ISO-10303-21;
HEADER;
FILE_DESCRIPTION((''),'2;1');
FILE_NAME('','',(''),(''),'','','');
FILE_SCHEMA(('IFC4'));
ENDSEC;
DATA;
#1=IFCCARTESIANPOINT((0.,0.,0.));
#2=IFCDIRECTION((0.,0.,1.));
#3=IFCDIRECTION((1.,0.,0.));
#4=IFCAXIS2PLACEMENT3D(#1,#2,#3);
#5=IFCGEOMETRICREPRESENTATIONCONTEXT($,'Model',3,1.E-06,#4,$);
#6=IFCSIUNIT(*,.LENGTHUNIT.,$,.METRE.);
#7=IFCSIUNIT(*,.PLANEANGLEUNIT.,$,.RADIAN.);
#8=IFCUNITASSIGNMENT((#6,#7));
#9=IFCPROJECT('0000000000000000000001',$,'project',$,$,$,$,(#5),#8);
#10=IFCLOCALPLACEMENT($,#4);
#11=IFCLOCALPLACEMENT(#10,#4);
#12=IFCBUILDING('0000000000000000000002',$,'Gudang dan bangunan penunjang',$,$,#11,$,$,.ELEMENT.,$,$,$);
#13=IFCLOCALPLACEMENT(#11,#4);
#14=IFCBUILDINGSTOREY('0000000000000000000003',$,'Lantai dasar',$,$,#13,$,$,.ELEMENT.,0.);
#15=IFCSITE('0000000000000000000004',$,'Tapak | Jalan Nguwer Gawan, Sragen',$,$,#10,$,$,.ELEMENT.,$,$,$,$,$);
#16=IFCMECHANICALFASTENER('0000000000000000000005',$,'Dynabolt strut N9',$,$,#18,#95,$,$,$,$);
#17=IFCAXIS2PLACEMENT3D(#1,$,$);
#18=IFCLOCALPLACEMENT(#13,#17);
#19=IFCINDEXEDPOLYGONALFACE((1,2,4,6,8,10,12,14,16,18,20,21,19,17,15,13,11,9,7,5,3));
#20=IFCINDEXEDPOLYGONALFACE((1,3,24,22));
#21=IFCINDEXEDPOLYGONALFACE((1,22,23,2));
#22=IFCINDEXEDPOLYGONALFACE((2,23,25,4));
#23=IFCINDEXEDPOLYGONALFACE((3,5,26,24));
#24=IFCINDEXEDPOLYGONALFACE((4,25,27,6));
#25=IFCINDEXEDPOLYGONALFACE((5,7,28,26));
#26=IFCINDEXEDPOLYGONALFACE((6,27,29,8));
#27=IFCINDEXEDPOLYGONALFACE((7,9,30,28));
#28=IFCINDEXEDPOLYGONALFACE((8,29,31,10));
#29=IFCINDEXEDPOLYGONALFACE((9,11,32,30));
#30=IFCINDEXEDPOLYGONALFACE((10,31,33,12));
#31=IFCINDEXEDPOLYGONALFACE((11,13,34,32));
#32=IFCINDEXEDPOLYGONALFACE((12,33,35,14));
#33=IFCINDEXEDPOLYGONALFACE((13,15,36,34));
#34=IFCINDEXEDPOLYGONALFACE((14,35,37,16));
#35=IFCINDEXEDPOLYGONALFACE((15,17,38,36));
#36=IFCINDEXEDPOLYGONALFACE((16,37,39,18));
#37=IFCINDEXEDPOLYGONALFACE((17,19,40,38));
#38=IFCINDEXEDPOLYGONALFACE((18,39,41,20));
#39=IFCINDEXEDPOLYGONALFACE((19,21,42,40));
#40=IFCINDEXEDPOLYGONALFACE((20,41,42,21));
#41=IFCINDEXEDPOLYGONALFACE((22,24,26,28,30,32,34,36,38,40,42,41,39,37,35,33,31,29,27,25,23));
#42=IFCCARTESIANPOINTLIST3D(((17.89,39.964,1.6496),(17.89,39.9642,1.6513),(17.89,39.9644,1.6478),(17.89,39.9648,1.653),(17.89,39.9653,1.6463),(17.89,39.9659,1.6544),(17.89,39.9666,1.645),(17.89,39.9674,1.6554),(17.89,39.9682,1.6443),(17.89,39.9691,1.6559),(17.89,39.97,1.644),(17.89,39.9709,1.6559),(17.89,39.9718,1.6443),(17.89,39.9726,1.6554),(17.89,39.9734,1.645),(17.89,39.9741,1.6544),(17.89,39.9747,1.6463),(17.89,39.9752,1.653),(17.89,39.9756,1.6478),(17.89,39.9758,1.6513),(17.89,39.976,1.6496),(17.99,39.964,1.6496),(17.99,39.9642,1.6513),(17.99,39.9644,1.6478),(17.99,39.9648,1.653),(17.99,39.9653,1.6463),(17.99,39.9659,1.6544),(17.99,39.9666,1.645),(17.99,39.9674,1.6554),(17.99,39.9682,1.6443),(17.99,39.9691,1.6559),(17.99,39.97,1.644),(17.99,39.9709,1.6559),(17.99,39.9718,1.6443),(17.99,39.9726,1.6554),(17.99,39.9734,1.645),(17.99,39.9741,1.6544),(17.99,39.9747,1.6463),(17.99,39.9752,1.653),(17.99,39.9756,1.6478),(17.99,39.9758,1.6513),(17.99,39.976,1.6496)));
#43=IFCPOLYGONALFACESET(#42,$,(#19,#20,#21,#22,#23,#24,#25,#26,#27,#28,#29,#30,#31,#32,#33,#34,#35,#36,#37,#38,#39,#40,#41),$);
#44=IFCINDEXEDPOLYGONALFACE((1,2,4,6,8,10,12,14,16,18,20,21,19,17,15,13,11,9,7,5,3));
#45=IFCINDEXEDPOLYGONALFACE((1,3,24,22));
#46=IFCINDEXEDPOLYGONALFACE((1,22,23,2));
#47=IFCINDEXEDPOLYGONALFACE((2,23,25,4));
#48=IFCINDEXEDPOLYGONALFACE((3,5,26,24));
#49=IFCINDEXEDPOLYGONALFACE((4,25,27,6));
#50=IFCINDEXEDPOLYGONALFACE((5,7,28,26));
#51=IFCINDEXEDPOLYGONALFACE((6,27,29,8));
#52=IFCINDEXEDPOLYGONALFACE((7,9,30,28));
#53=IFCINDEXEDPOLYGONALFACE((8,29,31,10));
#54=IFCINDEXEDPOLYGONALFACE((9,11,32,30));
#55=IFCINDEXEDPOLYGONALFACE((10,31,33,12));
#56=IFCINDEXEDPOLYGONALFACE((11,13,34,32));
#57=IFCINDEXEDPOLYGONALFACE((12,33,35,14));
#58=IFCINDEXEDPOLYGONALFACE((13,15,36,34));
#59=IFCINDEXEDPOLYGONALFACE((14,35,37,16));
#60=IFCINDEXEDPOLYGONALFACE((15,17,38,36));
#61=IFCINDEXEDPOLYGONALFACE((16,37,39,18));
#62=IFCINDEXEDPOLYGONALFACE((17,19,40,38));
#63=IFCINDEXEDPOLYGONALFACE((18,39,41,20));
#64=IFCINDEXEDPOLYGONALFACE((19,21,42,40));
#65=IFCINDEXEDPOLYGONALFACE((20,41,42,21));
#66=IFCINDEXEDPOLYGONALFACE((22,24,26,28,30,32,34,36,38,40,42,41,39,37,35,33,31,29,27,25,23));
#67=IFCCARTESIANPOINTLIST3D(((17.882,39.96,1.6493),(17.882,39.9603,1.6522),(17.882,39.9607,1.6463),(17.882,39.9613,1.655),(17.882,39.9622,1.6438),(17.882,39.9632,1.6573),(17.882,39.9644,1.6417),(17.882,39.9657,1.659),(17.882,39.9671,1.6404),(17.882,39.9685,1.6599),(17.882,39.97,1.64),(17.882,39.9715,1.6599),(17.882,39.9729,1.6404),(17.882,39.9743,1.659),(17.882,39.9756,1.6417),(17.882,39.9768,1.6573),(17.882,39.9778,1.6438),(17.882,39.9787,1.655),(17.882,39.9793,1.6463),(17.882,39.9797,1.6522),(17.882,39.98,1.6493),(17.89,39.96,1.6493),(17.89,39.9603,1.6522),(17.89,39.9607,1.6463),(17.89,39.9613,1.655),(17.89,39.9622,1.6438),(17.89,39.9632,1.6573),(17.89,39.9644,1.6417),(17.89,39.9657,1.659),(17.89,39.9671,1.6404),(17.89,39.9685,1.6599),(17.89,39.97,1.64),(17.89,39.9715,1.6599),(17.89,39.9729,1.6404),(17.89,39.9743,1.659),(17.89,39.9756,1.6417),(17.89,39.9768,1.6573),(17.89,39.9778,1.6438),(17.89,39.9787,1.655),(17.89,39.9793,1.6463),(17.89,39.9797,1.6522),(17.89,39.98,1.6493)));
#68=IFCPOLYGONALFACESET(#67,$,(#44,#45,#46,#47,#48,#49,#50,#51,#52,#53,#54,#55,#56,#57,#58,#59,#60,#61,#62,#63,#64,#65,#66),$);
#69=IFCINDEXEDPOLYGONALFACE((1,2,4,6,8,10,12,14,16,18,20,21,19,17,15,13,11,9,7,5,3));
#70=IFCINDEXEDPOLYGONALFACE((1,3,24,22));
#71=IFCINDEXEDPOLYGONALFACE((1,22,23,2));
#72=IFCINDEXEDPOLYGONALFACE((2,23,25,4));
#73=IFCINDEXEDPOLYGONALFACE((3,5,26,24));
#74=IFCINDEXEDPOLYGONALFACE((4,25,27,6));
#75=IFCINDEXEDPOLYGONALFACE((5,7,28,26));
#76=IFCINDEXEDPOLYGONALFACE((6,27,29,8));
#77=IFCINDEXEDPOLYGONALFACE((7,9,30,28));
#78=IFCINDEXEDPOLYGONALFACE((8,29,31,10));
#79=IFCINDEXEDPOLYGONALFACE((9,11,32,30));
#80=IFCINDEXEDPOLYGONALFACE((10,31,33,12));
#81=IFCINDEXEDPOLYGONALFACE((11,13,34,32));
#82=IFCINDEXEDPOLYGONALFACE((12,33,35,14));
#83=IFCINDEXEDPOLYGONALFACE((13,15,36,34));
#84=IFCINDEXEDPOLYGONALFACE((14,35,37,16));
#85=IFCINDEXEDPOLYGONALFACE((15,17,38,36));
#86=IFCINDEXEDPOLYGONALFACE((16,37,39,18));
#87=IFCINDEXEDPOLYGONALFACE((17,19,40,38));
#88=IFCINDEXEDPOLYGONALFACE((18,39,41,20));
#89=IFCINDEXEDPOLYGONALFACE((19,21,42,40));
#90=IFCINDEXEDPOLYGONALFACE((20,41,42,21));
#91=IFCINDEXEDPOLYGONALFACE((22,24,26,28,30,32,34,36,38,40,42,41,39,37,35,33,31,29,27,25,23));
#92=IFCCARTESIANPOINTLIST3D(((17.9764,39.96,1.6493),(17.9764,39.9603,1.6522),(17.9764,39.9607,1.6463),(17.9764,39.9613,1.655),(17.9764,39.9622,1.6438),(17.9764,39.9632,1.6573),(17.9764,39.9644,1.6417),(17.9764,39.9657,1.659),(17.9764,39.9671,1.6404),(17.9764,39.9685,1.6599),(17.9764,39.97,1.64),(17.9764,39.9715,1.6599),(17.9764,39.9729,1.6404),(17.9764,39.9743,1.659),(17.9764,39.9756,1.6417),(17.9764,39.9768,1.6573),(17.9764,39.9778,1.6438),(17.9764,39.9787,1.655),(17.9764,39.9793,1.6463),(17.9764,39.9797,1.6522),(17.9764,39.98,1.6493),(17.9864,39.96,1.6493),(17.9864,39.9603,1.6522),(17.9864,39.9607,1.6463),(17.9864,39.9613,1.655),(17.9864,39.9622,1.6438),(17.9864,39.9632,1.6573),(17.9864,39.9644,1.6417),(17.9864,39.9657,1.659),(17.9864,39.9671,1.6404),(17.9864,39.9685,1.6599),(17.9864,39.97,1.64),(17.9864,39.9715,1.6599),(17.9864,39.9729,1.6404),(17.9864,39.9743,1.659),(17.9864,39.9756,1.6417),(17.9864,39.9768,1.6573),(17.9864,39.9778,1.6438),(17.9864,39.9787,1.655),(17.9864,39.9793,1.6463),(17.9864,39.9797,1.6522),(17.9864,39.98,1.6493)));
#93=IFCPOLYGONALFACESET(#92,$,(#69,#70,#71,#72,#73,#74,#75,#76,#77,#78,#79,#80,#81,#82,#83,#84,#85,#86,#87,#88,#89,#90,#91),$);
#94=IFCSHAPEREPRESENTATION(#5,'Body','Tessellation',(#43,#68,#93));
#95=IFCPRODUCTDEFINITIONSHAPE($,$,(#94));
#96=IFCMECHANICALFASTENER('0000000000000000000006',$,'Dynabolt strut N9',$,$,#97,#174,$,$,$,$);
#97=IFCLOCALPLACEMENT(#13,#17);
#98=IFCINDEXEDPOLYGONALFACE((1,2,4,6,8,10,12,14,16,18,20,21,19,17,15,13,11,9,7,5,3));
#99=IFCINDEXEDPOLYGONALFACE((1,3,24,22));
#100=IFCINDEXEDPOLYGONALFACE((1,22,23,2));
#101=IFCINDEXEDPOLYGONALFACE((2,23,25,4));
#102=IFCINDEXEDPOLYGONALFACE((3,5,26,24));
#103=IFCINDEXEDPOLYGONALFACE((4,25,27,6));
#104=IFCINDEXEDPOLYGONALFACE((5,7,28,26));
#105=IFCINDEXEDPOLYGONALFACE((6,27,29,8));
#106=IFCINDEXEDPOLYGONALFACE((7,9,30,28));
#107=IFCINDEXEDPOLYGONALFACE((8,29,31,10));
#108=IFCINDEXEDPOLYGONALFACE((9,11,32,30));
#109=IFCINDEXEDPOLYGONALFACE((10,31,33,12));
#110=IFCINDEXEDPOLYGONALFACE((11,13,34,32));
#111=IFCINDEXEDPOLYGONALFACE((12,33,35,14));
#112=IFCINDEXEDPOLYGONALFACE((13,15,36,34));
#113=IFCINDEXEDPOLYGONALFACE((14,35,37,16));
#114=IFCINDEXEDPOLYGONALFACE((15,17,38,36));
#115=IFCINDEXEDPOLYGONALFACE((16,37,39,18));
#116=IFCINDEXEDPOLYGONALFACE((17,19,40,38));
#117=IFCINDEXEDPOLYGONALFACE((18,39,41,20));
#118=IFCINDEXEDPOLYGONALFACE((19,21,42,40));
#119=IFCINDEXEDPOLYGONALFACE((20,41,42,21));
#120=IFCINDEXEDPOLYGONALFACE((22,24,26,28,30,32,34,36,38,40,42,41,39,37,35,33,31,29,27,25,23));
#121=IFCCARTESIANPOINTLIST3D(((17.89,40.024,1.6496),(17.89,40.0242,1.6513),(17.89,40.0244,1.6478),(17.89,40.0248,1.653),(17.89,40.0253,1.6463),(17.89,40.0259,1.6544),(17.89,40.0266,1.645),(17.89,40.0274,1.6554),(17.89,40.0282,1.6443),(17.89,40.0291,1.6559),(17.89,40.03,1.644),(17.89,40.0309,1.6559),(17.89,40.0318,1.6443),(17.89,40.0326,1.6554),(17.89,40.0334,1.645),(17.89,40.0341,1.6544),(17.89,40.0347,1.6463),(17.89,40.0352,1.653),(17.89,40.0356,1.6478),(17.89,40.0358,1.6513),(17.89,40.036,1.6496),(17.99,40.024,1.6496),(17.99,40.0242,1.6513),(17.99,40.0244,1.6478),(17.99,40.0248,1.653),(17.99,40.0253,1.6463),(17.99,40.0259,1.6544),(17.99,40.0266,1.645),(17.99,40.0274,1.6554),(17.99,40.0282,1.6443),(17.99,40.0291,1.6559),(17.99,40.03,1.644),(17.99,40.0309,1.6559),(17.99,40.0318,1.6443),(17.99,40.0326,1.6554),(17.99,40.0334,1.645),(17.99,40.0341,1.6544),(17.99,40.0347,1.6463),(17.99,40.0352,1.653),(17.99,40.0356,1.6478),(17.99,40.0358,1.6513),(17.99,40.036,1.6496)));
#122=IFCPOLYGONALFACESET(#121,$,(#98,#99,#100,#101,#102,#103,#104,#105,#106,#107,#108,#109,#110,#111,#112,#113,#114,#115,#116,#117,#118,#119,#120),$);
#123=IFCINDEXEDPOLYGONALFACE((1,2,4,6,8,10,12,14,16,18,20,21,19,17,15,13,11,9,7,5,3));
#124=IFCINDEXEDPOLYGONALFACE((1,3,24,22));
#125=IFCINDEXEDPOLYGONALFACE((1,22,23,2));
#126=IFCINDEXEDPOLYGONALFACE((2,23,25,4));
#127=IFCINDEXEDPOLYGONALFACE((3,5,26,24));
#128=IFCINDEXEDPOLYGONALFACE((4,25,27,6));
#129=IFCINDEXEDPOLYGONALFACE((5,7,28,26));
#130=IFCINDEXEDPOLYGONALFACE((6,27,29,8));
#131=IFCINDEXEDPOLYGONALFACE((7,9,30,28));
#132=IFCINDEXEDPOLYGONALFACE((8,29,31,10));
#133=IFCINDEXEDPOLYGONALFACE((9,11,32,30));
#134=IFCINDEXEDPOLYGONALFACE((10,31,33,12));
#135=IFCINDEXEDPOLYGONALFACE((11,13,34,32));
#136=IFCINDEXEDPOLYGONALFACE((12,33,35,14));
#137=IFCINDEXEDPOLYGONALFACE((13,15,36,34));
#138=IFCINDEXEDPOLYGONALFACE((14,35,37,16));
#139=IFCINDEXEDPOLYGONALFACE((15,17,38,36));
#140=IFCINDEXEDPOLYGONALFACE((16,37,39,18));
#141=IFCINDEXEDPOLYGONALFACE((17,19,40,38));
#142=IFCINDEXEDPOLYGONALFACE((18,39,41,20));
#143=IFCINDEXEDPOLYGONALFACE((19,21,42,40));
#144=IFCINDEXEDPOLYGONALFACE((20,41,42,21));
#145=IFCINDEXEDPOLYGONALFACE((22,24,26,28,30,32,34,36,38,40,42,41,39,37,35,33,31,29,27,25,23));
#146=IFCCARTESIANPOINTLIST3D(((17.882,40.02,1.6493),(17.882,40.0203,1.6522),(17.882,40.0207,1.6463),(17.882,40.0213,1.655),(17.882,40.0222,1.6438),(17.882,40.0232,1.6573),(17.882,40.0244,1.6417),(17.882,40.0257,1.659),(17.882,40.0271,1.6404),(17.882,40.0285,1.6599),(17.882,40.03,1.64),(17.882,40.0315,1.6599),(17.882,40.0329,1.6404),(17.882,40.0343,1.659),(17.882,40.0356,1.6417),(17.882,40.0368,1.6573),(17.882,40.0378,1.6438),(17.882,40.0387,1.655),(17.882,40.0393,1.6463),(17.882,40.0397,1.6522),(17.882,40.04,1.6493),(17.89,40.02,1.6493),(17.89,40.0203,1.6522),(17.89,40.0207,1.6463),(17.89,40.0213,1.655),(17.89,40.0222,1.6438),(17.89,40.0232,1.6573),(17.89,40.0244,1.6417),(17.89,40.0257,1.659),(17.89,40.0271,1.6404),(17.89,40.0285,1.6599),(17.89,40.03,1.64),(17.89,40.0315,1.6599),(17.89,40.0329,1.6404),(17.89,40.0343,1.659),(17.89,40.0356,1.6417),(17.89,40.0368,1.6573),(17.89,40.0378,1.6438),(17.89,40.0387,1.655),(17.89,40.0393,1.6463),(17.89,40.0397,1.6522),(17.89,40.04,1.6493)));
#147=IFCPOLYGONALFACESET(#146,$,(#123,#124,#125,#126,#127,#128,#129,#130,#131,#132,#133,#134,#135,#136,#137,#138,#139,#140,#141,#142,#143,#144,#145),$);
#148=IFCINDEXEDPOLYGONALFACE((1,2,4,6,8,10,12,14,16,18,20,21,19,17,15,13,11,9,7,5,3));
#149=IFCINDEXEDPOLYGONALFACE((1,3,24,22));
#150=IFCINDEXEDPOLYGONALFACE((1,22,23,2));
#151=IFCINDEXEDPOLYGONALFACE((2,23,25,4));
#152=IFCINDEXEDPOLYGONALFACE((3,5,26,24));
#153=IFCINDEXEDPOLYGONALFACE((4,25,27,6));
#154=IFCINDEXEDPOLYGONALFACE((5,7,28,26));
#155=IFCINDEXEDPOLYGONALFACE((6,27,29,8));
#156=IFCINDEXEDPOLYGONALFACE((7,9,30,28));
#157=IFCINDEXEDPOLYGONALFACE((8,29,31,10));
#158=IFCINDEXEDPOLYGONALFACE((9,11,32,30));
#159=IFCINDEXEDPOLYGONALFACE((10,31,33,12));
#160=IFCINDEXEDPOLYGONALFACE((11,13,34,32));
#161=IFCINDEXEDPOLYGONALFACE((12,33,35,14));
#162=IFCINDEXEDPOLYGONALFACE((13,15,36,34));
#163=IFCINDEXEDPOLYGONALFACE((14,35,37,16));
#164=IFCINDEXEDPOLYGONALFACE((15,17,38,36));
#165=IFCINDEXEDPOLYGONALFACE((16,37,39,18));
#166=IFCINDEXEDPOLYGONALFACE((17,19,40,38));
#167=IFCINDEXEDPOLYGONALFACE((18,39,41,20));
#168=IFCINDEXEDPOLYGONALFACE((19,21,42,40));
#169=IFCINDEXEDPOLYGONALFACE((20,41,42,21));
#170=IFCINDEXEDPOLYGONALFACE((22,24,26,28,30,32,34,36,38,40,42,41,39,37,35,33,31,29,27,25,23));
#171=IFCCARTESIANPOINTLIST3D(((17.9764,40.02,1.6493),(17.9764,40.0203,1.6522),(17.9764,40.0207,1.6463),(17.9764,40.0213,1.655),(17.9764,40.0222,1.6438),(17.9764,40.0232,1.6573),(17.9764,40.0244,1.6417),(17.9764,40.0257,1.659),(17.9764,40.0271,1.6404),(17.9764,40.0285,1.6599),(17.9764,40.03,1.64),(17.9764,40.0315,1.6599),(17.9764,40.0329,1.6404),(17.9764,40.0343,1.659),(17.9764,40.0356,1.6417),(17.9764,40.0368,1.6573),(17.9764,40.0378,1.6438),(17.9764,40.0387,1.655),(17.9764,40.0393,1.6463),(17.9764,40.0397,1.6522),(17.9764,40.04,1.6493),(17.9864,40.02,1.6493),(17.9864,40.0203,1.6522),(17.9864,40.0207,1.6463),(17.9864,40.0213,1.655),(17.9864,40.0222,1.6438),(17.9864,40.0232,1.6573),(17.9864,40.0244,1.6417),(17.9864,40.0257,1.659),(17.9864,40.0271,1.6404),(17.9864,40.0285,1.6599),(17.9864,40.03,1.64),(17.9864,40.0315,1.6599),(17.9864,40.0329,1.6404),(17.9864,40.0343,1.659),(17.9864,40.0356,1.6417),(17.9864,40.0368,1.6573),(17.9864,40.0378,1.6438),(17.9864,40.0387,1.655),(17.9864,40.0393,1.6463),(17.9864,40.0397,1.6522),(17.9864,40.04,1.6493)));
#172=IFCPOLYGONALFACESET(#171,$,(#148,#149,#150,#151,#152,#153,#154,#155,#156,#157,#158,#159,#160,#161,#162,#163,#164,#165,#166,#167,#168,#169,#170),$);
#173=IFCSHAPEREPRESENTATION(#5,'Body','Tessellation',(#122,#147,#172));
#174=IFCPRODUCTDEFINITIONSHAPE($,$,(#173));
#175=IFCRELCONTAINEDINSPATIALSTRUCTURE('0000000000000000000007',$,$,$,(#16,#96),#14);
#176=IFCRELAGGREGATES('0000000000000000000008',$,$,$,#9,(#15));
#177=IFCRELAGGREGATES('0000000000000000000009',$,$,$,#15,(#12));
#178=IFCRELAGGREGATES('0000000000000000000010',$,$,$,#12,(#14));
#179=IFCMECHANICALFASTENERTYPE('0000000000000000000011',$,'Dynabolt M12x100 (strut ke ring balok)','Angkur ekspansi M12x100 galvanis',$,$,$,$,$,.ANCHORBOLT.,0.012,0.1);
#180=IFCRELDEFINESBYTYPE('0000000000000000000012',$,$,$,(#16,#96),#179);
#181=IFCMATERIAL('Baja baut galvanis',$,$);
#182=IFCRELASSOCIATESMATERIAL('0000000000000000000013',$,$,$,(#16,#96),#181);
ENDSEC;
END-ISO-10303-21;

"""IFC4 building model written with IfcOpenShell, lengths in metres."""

from ifc_helpers import new_model, si_unit, frame, origin_with_axes, place, context, project, spatial, circle, extrude, source, transform, mapped, material, type_object, type_shapes, element, save


model = new_model("IFC4")

# Units and contexts
model_context = context("Model", 3, precision=1e-06, world=origin_with_axes())
ifc_project = project(units=[si_unit("LENGTHUNIT", "METRE"), si_unit("PLANEANGLEUNIT", "RADIAN")], contexts=[model_context])

# Site, building, storey
site_placement = place(None, origin_with_axes())
site = spatial("IfcSite", under=ifc_project, at=site_placement, Name="Tapak | Jalan Nguwer Gawan, Sragen", CompositionType="ELEMENT")
building_placement = place(site_placement, origin_with_axes())
building = spatial("IfcBuilding", under=site, at=building_placement, Name="Gudang dan bangunan penunjang", CompositionType="ELEMENT")
storey_placement = place(building_placement, origin_with_axes())
storey = spatial("IfcBuildingStorey", under=building, at=storey_placement, Name="Lantai dasar", CompositionType="ELEMENT", Elevation=0.0)

# Mechanical fasteners
ifc_material = material(Name="Baja baut galvanis")
mechanical_fastener_type = type_object("IfcMechanicalFastenerType", Name="Dynabolt M12x100 (strut ke ring balok)", Description="Angkur ekspansi M12x100 galvanis", NominalDiameter=0.012, NominalLength=0.1, PredefinedType="ANCHORBOLT")
shared_shape = source(origin_with_axes(), model_context, "Body", "SweptSolid", [
    extrude(circle(Radius=0.006), origin_with_axes(), (0.0, 0.0, 1.0), 0.1),
    extrude(circle(Radius=0.01), frame((0.0, 0.0, -0.008), z_axis=(0.0, 0.0, 1.0), x_axis=(1.0, 0.0, 0.0)), (0.0, 0.0, 1.0), 0.008),
    extrude(circle(Radius=0.01), frame((0.0, 0.0, 0.0864), z_axis=(0.0, 0.0, 1.0), x_axis=(1.0, 0.0, 0.0)), (0.0, 0.0, 1.0), 0.01),
])
type_shapes(mechanical_fastener_type, [shared_shape])
placement = place(None, origin_with_axes())
element("IfcMechanicalFastener", 1, at=placement, inside=storey, type_object=mechanical_fastener_type, material=ifc_material, Name="Dynabolt strut N9", context=model_context, shape_type="MappedRepresentation", body=[
    mapped(shared_shape, transform((17.89, 39.97, 1.65), x_axis=(0.0, 0.0, -1.0), y_axis=(0.0, 1.0, 0.0), z_axis=(1.0, 0.0, 0.0), scale=1.0)),
])
element("IfcMechanicalFastener", 2, at=placement, inside=storey, type_object=mechanical_fastener_type, material=ifc_material, Name="Dynabolt strut N9", context=model_context, shape_type="MappedRepresentation", body=[
    mapped(shared_shape, transform((17.89, 40.03, 1.65), x_axis=(0.0, 0.0, -1.0), y_axis=(0.0, 1.0, 0.0), z_axis=(1.0, 0.0, 0.0), scale=1.0)),
])

save(model, "model.ifc")
